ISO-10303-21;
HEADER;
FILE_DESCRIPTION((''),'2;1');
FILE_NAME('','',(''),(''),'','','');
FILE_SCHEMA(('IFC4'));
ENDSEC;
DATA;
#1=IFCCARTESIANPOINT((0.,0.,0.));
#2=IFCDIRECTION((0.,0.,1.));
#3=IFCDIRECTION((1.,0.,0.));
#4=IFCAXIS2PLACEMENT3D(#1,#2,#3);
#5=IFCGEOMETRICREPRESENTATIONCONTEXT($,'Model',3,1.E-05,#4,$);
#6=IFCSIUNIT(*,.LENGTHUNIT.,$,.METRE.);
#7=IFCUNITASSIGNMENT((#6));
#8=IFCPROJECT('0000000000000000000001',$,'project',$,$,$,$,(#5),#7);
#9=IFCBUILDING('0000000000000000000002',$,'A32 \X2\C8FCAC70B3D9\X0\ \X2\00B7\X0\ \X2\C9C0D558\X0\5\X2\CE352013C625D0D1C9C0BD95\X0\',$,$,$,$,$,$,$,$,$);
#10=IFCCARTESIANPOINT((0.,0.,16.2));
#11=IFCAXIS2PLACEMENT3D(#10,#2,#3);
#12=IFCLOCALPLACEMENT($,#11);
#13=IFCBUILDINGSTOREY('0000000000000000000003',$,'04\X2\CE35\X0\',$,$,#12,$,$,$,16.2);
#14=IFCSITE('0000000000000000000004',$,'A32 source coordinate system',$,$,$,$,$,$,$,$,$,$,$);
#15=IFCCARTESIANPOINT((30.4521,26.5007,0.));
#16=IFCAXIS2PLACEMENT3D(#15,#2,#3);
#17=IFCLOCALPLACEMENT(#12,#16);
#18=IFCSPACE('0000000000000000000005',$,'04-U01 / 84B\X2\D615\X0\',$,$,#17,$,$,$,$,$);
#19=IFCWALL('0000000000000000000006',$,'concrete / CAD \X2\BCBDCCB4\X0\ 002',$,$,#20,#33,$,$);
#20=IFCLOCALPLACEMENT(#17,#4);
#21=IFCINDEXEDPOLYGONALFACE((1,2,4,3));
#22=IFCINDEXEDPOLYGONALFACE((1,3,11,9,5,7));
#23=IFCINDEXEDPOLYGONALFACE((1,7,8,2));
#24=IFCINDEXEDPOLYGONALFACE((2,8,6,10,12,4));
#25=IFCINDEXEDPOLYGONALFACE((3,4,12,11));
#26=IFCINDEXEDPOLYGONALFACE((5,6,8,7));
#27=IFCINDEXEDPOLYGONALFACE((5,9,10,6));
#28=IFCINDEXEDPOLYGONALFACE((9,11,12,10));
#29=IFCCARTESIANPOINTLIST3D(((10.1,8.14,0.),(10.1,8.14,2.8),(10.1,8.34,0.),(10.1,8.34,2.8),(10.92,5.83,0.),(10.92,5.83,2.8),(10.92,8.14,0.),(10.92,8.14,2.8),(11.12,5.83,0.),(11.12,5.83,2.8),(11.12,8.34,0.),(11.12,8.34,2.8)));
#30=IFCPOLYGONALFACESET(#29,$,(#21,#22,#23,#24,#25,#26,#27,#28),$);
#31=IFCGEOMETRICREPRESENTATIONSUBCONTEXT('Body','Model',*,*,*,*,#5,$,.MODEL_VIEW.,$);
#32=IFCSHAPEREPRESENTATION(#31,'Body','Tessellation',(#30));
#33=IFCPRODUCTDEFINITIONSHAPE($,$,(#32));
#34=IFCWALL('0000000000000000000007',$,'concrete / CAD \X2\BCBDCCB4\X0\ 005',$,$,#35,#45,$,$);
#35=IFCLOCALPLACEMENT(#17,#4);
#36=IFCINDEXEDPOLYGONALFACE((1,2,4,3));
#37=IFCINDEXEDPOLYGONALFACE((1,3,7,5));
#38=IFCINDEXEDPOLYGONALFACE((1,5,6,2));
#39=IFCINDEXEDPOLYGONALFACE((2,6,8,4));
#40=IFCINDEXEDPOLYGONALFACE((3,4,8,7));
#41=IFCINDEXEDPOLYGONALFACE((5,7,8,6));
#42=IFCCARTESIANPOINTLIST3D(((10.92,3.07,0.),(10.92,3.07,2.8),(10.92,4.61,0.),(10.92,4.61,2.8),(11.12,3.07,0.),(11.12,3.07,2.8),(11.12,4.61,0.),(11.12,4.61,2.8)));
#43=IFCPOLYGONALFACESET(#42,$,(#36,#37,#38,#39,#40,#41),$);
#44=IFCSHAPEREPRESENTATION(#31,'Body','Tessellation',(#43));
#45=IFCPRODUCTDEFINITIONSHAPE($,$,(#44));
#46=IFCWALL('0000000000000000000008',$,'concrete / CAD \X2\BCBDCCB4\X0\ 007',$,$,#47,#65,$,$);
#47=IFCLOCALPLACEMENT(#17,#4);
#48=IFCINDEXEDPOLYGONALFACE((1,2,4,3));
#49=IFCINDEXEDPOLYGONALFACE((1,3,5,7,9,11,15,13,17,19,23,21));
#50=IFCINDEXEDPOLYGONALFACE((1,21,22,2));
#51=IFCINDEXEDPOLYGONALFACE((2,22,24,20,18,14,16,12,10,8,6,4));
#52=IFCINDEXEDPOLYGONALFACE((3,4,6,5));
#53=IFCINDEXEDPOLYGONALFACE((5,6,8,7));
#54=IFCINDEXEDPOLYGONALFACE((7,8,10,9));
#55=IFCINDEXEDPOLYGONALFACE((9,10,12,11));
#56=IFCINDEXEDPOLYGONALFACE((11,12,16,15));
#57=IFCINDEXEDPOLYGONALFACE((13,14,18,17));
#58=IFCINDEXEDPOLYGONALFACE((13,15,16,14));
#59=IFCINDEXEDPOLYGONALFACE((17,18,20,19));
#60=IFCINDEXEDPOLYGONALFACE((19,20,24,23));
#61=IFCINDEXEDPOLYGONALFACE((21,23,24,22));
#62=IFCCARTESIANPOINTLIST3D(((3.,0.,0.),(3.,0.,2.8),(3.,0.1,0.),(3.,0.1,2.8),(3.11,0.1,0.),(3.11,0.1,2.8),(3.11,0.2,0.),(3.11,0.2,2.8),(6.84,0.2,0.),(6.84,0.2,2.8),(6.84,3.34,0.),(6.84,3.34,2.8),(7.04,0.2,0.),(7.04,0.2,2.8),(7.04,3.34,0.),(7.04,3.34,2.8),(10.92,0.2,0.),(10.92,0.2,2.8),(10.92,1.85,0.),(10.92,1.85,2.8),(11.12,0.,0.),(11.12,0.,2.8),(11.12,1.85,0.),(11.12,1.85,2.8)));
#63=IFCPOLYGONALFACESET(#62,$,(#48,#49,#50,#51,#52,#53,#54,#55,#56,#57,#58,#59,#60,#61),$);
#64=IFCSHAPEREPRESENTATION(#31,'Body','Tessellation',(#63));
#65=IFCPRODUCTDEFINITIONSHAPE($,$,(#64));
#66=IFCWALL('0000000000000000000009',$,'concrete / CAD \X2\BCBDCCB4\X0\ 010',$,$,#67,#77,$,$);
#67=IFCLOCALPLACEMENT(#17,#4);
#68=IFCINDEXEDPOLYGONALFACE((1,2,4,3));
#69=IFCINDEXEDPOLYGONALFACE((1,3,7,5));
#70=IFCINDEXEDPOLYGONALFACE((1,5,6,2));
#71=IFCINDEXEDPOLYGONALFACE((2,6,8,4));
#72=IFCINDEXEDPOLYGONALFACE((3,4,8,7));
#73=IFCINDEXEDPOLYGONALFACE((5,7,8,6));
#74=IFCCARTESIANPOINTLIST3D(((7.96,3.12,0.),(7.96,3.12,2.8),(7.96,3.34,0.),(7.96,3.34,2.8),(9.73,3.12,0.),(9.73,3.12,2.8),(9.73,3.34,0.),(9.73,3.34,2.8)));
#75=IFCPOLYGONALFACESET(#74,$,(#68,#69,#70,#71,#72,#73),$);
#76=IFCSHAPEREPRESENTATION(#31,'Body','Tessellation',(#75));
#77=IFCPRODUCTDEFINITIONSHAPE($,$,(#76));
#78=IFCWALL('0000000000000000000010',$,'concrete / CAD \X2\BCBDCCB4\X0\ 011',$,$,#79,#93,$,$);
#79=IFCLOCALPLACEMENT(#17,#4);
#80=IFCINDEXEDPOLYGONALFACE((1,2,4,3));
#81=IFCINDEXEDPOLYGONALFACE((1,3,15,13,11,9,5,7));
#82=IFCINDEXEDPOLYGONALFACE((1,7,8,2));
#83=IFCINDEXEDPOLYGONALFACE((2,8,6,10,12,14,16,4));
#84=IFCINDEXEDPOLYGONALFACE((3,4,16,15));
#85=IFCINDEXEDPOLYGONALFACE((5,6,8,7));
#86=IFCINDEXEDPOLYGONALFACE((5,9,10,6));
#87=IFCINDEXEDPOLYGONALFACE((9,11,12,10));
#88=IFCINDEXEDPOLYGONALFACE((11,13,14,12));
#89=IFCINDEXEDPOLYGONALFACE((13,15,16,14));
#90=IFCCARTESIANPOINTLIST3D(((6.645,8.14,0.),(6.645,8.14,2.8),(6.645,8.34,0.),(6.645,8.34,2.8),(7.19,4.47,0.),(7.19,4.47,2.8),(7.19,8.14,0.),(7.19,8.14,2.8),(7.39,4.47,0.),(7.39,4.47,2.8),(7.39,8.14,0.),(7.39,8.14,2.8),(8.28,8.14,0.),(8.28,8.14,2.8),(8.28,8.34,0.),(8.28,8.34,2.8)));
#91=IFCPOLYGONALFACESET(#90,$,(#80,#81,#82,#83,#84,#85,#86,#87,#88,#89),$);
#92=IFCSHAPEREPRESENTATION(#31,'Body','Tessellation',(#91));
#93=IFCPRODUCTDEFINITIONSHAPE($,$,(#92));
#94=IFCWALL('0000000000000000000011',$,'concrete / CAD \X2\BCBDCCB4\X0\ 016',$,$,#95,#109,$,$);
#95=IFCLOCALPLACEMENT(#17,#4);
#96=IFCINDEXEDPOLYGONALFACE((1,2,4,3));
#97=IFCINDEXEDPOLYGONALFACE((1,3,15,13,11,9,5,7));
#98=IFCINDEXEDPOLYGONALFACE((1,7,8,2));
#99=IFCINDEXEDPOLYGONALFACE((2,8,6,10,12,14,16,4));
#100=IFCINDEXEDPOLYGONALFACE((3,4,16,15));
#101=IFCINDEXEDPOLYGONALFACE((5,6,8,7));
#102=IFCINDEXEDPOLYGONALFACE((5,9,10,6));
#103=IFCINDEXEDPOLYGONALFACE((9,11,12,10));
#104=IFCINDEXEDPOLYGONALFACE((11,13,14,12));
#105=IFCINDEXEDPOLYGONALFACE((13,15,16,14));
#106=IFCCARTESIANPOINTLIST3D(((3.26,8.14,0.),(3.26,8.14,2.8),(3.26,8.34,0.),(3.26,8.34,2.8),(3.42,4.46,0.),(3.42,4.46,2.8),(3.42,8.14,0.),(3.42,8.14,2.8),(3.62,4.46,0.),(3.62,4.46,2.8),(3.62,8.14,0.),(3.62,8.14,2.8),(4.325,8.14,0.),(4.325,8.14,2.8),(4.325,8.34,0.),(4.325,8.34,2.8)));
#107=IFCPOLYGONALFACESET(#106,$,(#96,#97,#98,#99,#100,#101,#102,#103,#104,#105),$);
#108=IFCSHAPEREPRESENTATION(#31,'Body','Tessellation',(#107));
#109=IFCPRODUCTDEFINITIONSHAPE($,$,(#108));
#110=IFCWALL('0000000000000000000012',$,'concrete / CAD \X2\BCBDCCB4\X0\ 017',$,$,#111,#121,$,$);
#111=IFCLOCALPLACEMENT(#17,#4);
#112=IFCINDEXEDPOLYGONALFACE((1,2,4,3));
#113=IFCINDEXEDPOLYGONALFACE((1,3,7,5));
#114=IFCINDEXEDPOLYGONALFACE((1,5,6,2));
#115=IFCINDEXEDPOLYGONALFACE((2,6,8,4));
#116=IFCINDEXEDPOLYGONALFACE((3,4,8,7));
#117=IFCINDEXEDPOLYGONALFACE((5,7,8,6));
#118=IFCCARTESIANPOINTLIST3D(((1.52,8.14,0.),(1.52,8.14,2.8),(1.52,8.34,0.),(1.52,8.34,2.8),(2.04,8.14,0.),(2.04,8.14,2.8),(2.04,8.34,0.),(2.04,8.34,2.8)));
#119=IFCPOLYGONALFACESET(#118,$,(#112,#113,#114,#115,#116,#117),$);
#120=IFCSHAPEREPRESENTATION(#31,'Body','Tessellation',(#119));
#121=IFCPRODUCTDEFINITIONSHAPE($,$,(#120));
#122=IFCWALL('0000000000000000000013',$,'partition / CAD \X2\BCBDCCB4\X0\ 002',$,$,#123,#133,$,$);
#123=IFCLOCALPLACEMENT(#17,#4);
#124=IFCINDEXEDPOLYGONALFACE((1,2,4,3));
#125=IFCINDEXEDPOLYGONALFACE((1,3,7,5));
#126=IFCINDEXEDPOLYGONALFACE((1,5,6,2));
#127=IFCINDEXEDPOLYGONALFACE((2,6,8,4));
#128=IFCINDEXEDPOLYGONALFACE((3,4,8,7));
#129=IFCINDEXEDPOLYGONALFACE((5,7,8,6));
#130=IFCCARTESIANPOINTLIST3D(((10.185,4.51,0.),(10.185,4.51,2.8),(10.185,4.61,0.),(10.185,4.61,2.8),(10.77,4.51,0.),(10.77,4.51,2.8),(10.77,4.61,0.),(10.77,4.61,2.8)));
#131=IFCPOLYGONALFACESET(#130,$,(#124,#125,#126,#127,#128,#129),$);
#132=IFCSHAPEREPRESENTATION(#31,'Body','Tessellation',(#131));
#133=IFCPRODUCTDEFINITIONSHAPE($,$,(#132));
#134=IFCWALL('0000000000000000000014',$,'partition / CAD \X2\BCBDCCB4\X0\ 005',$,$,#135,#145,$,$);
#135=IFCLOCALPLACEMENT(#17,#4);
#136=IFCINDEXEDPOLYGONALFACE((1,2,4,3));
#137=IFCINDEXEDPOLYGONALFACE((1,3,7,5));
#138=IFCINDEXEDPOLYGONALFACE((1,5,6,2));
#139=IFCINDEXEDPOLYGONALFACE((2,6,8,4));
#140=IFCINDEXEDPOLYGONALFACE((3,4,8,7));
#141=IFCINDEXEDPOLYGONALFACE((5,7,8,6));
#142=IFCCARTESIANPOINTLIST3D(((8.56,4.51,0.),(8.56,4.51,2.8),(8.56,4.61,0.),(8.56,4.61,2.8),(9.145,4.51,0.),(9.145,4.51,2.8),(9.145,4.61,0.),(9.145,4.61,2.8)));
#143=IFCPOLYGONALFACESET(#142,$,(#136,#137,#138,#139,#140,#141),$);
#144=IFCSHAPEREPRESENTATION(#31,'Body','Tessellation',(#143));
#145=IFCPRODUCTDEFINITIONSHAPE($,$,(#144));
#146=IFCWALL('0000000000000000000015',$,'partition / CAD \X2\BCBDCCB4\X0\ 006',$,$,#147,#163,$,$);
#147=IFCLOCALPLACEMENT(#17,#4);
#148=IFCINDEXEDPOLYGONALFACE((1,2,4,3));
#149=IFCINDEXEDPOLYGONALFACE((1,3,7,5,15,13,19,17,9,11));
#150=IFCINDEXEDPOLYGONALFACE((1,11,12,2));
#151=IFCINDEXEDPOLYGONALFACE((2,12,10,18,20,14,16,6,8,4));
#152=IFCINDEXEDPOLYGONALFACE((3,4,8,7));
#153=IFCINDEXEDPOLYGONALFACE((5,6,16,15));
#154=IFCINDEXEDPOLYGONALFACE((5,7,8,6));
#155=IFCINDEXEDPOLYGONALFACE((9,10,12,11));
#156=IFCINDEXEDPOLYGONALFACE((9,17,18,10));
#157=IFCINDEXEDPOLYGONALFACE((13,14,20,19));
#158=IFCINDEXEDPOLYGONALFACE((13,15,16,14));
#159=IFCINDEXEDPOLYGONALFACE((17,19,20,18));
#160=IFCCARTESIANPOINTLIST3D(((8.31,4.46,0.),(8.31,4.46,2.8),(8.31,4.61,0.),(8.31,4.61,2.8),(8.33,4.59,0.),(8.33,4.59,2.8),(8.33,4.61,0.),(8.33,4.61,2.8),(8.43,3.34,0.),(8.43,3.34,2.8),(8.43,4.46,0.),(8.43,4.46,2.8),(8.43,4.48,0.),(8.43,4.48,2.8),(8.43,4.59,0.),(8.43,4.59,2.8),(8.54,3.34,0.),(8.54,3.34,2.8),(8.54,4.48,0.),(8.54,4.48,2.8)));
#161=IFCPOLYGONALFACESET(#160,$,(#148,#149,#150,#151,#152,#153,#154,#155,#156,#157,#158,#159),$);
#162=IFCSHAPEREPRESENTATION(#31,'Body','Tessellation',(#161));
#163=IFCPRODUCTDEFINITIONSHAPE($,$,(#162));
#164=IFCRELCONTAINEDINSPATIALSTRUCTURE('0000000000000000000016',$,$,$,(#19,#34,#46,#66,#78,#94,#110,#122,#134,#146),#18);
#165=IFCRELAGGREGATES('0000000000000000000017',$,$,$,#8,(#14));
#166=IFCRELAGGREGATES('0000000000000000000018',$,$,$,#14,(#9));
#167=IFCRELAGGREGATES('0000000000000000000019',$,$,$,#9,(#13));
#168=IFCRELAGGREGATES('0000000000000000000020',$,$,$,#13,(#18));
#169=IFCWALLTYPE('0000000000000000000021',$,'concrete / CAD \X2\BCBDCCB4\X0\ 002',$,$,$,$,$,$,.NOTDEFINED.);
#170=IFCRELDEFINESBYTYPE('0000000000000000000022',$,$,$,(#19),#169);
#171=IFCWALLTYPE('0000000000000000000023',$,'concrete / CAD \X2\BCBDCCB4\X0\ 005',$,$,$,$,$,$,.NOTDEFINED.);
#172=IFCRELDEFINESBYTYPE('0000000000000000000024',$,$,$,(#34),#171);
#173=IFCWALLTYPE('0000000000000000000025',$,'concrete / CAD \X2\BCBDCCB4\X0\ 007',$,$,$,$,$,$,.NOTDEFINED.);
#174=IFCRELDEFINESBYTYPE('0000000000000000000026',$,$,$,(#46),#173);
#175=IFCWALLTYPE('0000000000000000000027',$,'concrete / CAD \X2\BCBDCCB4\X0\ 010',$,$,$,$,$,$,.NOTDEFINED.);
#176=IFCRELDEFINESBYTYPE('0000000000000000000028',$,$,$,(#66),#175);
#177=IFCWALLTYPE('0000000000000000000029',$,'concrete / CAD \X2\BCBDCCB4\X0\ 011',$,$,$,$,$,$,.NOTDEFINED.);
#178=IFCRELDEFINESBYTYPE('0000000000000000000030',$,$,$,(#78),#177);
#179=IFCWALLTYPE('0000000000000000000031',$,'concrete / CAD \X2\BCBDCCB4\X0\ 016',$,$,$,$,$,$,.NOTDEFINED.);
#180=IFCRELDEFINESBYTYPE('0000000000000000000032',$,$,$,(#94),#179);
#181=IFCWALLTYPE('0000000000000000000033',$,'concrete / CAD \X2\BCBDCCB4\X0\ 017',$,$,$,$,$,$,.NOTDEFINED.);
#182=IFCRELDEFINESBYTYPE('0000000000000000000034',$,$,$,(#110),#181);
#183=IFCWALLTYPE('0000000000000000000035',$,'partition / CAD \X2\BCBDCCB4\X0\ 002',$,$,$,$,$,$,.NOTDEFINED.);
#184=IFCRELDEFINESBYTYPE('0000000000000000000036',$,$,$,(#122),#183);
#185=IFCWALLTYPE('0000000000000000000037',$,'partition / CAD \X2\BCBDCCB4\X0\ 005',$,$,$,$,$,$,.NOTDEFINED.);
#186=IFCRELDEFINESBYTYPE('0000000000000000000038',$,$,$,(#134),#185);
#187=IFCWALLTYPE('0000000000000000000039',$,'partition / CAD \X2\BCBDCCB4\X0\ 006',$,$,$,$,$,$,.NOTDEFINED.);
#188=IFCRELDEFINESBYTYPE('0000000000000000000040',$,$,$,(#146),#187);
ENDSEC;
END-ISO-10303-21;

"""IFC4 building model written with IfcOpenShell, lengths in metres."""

from ifc_helpers import new_model, si_unit, frame, origin, origin_with_axes, place, context, subcontext, project, spatial, polyline, outline, extrude, source, transform, mapped, type_object, type_shapes, element, save


model = new_model("IFC4")

# Units and contexts
model_context = context("Model", 3, precision=1e-05, world=origin_with_axes())
body_context = subcontext(model_context, "Body", "Model", "MODEL_VIEW")
ifc_project = project(units=[si_unit("LENGTHUNIT", "METRE")], contexts=[model_context])

# Site, building, storey, space
site = spatial("IfcSite", under=ifc_project, Name="A32 source coordinate system")
building = spatial("IfcBuilding", under=site, Name="A32 주거동 · 지하5층–옥탑지붕")
storey_placement = place(None, frame((0.0, 0.0, 16.2), z_axis=(0.0, 0.0, 1.0), x_axis=(1.0, 0.0, 0.0)))
storey = spatial("IfcBuildingStorey", under=building, at=storey_placement, Name="04층", Elevation=16.2)
space_1_placement = place(storey_placement, frame((30.4521, 26.5007, 0.0), z_axis=(0.0, 0.0, 1.0), x_axis=(1.0, 0.0, 0.0)))
space_1 = spatial("IfcSpace", under=storey, at=space_1_placement, Name="04-U01 / 84B형")

# Walls
wall_type_1 = type_object("IfcWallType", Name="concrete / CAD 벽체 002", PredefinedType="NOTDEFINED")
shared_shape_1 = source(origin(), body_context, "Body", "SweptSolid", [
    extrude(outline(polyline([(11.12, 5.83), (10.92, 5.83), (10.92, 8.14), (10.1, 8.14), (10.1, 8.34), (11.12, 8.34), (11.12, 5.83)])), origin(), (0.0, 0.0, 1.0), 2.8),
])
type_shapes(wall_type_1, [shared_shape_1])
wall_1_placement = place(space_1_placement, origin_with_axes())
element("IfcWall", 1, at=wall_1_placement, inside=space_1, type_object=wall_type_1, Name="concrete / CAD 벽체 002", context=body_context, shape_type="MappedRepresentation", body=[
    mapped(shared_shape_1, transform((0.0, 0.0, 0.0), scale=1.0)),
])
wall_type_2 = type_object("IfcWallType", Name="concrete / CAD 벽체 005", PredefinedType="NOTDEFINED")
shared_shape_2 = source(origin(), body_context, "Body", "SweptSolid", [
    extrude(outline(polyline([(11.12, 3.07), (10.92, 3.07), (10.92, 4.61), (11.12, 4.61), (11.12, 3.07)])), origin(), (0.0, 0.0, 1.0), 2.8),
])
type_shapes(wall_type_2, [shared_shape_2])
wall_2_placement = place(space_1_placement, origin_with_axes())
element("IfcWall", 2, at=wall_2_placement, inside=space_1, type_object=wall_type_2, Name="concrete / CAD 벽체 005", context=body_context, shape_type="MappedRepresentation", body=[
    mapped(shared_shape_2, transform((0.0, 0.0, 0.0), scale=1.0)),
])
wall_type_3 = type_object("IfcWallType", Name="concrete / CAD 벽체 007", PredefinedType="NOTDEFINED")
shared_shape_3 = source(origin(), body_context, "Body", "SweptSolid", [
    extrude(outline(polyline([(3.0, 0.0), (3.0, 0.1), (3.11, 0.1), (3.11, 0.2), (6.84, 0.2), (6.84, 3.34), (7.04, 3.34), (7.04, 0.2), (10.92, 0.2), (10.92, 1.85), (11.12, 1.85), (11.12, 0.0), (3.0, 0.0)])), origin(), (0.0, 0.0, 1.0), 2.8),
])
type_shapes(wall_type_3, [shared_shape_3])
wall_3_placement = place(space_1_placement, origin_with_axes())
element("IfcWall", 3, at=wall_3_placement, inside=space_1, type_object=wall_type_3, Name="concrete / CAD 벽체 007", context=body_context, shape_type="MappedRepresentation", body=[
    mapped(shared_shape_3, transform((0.0, 0.0, 0.0), scale=1.0)),
])
wall_type_4 = type_object("IfcWallType", Name="concrete / CAD 벽체 010", PredefinedType="NOTDEFINED")
shared_shape_4 = source(origin(), body_context, "Body", "SweptSolid", [
    extrude(outline(polyline([(7.96, 3.12), (7.96, 3.34), (9.73, 3.34), (9.73, 3.12), (7.96, 3.12)])), origin(), (0.0, 0.0, 1.0), 2.8),
])
type_shapes(wall_type_4, [shared_shape_4])
wall_4_placement = place(space_1_placement, origin_with_axes())
element("IfcWall", 4, at=wall_4_placement, inside=space_1, type_object=wall_type_4, Name="concrete / CAD 벽체 010", context=body_context, shape_type="MappedRepresentation", body=[
    mapped(shared_shape_4, transform((0.0, 0.0, 0.0), scale=1.0)),
])
wall_type_5 = type_object("IfcWallType", Name="concrete / CAD 벽체 011", PredefinedType="NOTDEFINED")
shared_shape_5 = source(origin(), body_context, "Body", "SweptSolid", [
    extrude(outline(polyline([(7.19, 8.14), (6.645, 8.14), (6.645, 8.34), (8.28, 8.34), (8.28, 8.14), (7.39, 8.14), (7.39, 4.47), (7.19, 4.47), (7.19, 8.14)])), origin(), (0.0, 0.0, 1.0), 2.8),
])
type_shapes(wall_type_5, [shared_shape_5])
wall_5_placement = place(space_1_placement, origin_with_axes())
element("IfcWall", 5, at=wall_5_placement, inside=space_1, type_object=wall_type_5, Name="concrete / CAD 벽체 011", context=body_context, shape_type="MappedRepresentation", body=[
    mapped(shared_shape_5, transform((0.0, 0.0, 0.0), scale=1.0)),
])
wall_type_6 = type_object("IfcWallType", Name="concrete / CAD 벽체 016", PredefinedType="NOTDEFINED")
shared_shape_6 = source(origin(), body_context, "Body", "SweptSolid", [
    extrude(outline(polyline([(3.26, 8.14), (3.26, 8.34), (4.325, 8.34), (4.325, 8.14), (3.62, 8.14), (3.62, 4.46), (3.42, 4.46), (3.42, 8.14), (3.26, 8.14)])), origin(), (0.0, 0.0, 1.0), 2.8),
])
type_shapes(wall_type_6, [shared_shape_6])
wall_6_placement = place(space_1_placement, origin_with_axes())
element("IfcWall", 6, at=wall_6_placement, inside=space_1, type_object=wall_type_6, Name="concrete / CAD 벽체 016", context=body_context, shape_type="MappedRepresentation", body=[
    mapped(shared_shape_6, transform((0.0, 0.0, 0.0), scale=1.0)),
])
wall_type_7 = type_object("IfcWallType", Name="concrete / CAD 벽체 017", PredefinedType="NOTDEFINED")
shared_shape_7 = source(origin(), body_context, "Body", "SweptSolid", [
    extrude(outline(polyline([(1.52, 8.34), (2.04, 8.34), (2.04, 8.14), (1.52, 8.14), (1.52, 8.34)])), origin(), (0.0, 0.0, 1.0), 2.8),
])
type_shapes(wall_type_7, [shared_shape_7])
wall_7_placement = place(space_1_placement, origin_with_axes())
element("IfcWall", 7, at=wall_7_placement, inside=space_1, type_object=wall_type_7, Name="concrete / CAD 벽체 017", context=body_context, shape_type="MappedRepresentation", body=[
    mapped(shared_shape_7, transform((0.0, 0.0, 0.0), scale=1.0)),
])
wall_type_8 = type_object("IfcWallType", Name="partition / CAD 벽체 002", PredefinedType="NOTDEFINED")
shared_shape_8 = source(origin(), body_context, "Body", "SweptSolid", [
    extrude(outline(polyline([(10.185, 4.51), (10.185, 4.61), (10.77, 4.61), (10.77, 4.51), (10.185, 4.51)])), origin(), (0.0, 0.0, 1.0), 2.8),
])
type_shapes(wall_type_8, [shared_shape_8])
wall_8_placement = place(space_1_placement, origin_with_axes())
element("IfcWall", 8, at=wall_8_placement, inside=space_1, type_object=wall_type_8, Name="partition / CAD 벽체 002", context=body_context, shape_type="MappedRepresentation", body=[
    mapped(shared_shape_8, transform((0.0, 0.0, 0.0), scale=1.0)),
])
wall_type_9 = type_object("IfcWallType", Name="partition / CAD 벽체 005", PredefinedType="NOTDEFINED")
shared_shape_9 = source(origin(), body_context, "Body", "SweptSolid", [
    extrude(outline(polyline([(8.56, 4.51), (8.56, 4.61), (9.145, 4.61), (9.145, 4.51), (8.56, 4.51)])), origin(), (0.0, 0.0, 1.0), 2.8),
])
type_shapes(wall_type_9, [shared_shape_9])
wall_9_placement = place(space_1_placement, origin_with_axes())
element("IfcWall", 9, at=wall_9_placement, inside=space_1, type_object=wall_type_9, Name="partition / CAD 벽체 005", context=body_context, shape_type="MappedRepresentation", body=[
    mapped(shared_shape_9, transform((0.0, 0.0, 0.0), scale=1.0)),
])
wall_type_10 = type_object("IfcWallType", Name="partition / CAD 벽체 006", PredefinedType="NOTDEFINED")
shared_shape_10 = source(origin(), body_context, "Body", "SweptSolid", [
    extrude(outline(polyline([(8.43, 4.46), (8.31, 4.46), (8.31, 4.61), (8.33, 4.61), (8.33, 4.59), (8.43, 4.59), (8.43, 4.48), (8.54, 4.48), (8.54, 3.34), (8.43, 3.34), (8.43, 4.46)])), origin(), (0.0, 0.0, 1.0), 2.8),
])
type_shapes(wall_type_10, [shared_shape_10])
wall_10_placement = place(space_1_placement, origin_with_axes())
element("IfcWall", 10, at=wall_10_placement, inside=space_1, type_object=wall_type_10, Name="partition / CAD 벽체 006", context=body_context, shape_type="MappedRepresentation", body=[
    mapped(shared_shape_10, transform((0.0, 0.0, 0.0), scale=1.0)),
])

save(model, "model.ifc")
